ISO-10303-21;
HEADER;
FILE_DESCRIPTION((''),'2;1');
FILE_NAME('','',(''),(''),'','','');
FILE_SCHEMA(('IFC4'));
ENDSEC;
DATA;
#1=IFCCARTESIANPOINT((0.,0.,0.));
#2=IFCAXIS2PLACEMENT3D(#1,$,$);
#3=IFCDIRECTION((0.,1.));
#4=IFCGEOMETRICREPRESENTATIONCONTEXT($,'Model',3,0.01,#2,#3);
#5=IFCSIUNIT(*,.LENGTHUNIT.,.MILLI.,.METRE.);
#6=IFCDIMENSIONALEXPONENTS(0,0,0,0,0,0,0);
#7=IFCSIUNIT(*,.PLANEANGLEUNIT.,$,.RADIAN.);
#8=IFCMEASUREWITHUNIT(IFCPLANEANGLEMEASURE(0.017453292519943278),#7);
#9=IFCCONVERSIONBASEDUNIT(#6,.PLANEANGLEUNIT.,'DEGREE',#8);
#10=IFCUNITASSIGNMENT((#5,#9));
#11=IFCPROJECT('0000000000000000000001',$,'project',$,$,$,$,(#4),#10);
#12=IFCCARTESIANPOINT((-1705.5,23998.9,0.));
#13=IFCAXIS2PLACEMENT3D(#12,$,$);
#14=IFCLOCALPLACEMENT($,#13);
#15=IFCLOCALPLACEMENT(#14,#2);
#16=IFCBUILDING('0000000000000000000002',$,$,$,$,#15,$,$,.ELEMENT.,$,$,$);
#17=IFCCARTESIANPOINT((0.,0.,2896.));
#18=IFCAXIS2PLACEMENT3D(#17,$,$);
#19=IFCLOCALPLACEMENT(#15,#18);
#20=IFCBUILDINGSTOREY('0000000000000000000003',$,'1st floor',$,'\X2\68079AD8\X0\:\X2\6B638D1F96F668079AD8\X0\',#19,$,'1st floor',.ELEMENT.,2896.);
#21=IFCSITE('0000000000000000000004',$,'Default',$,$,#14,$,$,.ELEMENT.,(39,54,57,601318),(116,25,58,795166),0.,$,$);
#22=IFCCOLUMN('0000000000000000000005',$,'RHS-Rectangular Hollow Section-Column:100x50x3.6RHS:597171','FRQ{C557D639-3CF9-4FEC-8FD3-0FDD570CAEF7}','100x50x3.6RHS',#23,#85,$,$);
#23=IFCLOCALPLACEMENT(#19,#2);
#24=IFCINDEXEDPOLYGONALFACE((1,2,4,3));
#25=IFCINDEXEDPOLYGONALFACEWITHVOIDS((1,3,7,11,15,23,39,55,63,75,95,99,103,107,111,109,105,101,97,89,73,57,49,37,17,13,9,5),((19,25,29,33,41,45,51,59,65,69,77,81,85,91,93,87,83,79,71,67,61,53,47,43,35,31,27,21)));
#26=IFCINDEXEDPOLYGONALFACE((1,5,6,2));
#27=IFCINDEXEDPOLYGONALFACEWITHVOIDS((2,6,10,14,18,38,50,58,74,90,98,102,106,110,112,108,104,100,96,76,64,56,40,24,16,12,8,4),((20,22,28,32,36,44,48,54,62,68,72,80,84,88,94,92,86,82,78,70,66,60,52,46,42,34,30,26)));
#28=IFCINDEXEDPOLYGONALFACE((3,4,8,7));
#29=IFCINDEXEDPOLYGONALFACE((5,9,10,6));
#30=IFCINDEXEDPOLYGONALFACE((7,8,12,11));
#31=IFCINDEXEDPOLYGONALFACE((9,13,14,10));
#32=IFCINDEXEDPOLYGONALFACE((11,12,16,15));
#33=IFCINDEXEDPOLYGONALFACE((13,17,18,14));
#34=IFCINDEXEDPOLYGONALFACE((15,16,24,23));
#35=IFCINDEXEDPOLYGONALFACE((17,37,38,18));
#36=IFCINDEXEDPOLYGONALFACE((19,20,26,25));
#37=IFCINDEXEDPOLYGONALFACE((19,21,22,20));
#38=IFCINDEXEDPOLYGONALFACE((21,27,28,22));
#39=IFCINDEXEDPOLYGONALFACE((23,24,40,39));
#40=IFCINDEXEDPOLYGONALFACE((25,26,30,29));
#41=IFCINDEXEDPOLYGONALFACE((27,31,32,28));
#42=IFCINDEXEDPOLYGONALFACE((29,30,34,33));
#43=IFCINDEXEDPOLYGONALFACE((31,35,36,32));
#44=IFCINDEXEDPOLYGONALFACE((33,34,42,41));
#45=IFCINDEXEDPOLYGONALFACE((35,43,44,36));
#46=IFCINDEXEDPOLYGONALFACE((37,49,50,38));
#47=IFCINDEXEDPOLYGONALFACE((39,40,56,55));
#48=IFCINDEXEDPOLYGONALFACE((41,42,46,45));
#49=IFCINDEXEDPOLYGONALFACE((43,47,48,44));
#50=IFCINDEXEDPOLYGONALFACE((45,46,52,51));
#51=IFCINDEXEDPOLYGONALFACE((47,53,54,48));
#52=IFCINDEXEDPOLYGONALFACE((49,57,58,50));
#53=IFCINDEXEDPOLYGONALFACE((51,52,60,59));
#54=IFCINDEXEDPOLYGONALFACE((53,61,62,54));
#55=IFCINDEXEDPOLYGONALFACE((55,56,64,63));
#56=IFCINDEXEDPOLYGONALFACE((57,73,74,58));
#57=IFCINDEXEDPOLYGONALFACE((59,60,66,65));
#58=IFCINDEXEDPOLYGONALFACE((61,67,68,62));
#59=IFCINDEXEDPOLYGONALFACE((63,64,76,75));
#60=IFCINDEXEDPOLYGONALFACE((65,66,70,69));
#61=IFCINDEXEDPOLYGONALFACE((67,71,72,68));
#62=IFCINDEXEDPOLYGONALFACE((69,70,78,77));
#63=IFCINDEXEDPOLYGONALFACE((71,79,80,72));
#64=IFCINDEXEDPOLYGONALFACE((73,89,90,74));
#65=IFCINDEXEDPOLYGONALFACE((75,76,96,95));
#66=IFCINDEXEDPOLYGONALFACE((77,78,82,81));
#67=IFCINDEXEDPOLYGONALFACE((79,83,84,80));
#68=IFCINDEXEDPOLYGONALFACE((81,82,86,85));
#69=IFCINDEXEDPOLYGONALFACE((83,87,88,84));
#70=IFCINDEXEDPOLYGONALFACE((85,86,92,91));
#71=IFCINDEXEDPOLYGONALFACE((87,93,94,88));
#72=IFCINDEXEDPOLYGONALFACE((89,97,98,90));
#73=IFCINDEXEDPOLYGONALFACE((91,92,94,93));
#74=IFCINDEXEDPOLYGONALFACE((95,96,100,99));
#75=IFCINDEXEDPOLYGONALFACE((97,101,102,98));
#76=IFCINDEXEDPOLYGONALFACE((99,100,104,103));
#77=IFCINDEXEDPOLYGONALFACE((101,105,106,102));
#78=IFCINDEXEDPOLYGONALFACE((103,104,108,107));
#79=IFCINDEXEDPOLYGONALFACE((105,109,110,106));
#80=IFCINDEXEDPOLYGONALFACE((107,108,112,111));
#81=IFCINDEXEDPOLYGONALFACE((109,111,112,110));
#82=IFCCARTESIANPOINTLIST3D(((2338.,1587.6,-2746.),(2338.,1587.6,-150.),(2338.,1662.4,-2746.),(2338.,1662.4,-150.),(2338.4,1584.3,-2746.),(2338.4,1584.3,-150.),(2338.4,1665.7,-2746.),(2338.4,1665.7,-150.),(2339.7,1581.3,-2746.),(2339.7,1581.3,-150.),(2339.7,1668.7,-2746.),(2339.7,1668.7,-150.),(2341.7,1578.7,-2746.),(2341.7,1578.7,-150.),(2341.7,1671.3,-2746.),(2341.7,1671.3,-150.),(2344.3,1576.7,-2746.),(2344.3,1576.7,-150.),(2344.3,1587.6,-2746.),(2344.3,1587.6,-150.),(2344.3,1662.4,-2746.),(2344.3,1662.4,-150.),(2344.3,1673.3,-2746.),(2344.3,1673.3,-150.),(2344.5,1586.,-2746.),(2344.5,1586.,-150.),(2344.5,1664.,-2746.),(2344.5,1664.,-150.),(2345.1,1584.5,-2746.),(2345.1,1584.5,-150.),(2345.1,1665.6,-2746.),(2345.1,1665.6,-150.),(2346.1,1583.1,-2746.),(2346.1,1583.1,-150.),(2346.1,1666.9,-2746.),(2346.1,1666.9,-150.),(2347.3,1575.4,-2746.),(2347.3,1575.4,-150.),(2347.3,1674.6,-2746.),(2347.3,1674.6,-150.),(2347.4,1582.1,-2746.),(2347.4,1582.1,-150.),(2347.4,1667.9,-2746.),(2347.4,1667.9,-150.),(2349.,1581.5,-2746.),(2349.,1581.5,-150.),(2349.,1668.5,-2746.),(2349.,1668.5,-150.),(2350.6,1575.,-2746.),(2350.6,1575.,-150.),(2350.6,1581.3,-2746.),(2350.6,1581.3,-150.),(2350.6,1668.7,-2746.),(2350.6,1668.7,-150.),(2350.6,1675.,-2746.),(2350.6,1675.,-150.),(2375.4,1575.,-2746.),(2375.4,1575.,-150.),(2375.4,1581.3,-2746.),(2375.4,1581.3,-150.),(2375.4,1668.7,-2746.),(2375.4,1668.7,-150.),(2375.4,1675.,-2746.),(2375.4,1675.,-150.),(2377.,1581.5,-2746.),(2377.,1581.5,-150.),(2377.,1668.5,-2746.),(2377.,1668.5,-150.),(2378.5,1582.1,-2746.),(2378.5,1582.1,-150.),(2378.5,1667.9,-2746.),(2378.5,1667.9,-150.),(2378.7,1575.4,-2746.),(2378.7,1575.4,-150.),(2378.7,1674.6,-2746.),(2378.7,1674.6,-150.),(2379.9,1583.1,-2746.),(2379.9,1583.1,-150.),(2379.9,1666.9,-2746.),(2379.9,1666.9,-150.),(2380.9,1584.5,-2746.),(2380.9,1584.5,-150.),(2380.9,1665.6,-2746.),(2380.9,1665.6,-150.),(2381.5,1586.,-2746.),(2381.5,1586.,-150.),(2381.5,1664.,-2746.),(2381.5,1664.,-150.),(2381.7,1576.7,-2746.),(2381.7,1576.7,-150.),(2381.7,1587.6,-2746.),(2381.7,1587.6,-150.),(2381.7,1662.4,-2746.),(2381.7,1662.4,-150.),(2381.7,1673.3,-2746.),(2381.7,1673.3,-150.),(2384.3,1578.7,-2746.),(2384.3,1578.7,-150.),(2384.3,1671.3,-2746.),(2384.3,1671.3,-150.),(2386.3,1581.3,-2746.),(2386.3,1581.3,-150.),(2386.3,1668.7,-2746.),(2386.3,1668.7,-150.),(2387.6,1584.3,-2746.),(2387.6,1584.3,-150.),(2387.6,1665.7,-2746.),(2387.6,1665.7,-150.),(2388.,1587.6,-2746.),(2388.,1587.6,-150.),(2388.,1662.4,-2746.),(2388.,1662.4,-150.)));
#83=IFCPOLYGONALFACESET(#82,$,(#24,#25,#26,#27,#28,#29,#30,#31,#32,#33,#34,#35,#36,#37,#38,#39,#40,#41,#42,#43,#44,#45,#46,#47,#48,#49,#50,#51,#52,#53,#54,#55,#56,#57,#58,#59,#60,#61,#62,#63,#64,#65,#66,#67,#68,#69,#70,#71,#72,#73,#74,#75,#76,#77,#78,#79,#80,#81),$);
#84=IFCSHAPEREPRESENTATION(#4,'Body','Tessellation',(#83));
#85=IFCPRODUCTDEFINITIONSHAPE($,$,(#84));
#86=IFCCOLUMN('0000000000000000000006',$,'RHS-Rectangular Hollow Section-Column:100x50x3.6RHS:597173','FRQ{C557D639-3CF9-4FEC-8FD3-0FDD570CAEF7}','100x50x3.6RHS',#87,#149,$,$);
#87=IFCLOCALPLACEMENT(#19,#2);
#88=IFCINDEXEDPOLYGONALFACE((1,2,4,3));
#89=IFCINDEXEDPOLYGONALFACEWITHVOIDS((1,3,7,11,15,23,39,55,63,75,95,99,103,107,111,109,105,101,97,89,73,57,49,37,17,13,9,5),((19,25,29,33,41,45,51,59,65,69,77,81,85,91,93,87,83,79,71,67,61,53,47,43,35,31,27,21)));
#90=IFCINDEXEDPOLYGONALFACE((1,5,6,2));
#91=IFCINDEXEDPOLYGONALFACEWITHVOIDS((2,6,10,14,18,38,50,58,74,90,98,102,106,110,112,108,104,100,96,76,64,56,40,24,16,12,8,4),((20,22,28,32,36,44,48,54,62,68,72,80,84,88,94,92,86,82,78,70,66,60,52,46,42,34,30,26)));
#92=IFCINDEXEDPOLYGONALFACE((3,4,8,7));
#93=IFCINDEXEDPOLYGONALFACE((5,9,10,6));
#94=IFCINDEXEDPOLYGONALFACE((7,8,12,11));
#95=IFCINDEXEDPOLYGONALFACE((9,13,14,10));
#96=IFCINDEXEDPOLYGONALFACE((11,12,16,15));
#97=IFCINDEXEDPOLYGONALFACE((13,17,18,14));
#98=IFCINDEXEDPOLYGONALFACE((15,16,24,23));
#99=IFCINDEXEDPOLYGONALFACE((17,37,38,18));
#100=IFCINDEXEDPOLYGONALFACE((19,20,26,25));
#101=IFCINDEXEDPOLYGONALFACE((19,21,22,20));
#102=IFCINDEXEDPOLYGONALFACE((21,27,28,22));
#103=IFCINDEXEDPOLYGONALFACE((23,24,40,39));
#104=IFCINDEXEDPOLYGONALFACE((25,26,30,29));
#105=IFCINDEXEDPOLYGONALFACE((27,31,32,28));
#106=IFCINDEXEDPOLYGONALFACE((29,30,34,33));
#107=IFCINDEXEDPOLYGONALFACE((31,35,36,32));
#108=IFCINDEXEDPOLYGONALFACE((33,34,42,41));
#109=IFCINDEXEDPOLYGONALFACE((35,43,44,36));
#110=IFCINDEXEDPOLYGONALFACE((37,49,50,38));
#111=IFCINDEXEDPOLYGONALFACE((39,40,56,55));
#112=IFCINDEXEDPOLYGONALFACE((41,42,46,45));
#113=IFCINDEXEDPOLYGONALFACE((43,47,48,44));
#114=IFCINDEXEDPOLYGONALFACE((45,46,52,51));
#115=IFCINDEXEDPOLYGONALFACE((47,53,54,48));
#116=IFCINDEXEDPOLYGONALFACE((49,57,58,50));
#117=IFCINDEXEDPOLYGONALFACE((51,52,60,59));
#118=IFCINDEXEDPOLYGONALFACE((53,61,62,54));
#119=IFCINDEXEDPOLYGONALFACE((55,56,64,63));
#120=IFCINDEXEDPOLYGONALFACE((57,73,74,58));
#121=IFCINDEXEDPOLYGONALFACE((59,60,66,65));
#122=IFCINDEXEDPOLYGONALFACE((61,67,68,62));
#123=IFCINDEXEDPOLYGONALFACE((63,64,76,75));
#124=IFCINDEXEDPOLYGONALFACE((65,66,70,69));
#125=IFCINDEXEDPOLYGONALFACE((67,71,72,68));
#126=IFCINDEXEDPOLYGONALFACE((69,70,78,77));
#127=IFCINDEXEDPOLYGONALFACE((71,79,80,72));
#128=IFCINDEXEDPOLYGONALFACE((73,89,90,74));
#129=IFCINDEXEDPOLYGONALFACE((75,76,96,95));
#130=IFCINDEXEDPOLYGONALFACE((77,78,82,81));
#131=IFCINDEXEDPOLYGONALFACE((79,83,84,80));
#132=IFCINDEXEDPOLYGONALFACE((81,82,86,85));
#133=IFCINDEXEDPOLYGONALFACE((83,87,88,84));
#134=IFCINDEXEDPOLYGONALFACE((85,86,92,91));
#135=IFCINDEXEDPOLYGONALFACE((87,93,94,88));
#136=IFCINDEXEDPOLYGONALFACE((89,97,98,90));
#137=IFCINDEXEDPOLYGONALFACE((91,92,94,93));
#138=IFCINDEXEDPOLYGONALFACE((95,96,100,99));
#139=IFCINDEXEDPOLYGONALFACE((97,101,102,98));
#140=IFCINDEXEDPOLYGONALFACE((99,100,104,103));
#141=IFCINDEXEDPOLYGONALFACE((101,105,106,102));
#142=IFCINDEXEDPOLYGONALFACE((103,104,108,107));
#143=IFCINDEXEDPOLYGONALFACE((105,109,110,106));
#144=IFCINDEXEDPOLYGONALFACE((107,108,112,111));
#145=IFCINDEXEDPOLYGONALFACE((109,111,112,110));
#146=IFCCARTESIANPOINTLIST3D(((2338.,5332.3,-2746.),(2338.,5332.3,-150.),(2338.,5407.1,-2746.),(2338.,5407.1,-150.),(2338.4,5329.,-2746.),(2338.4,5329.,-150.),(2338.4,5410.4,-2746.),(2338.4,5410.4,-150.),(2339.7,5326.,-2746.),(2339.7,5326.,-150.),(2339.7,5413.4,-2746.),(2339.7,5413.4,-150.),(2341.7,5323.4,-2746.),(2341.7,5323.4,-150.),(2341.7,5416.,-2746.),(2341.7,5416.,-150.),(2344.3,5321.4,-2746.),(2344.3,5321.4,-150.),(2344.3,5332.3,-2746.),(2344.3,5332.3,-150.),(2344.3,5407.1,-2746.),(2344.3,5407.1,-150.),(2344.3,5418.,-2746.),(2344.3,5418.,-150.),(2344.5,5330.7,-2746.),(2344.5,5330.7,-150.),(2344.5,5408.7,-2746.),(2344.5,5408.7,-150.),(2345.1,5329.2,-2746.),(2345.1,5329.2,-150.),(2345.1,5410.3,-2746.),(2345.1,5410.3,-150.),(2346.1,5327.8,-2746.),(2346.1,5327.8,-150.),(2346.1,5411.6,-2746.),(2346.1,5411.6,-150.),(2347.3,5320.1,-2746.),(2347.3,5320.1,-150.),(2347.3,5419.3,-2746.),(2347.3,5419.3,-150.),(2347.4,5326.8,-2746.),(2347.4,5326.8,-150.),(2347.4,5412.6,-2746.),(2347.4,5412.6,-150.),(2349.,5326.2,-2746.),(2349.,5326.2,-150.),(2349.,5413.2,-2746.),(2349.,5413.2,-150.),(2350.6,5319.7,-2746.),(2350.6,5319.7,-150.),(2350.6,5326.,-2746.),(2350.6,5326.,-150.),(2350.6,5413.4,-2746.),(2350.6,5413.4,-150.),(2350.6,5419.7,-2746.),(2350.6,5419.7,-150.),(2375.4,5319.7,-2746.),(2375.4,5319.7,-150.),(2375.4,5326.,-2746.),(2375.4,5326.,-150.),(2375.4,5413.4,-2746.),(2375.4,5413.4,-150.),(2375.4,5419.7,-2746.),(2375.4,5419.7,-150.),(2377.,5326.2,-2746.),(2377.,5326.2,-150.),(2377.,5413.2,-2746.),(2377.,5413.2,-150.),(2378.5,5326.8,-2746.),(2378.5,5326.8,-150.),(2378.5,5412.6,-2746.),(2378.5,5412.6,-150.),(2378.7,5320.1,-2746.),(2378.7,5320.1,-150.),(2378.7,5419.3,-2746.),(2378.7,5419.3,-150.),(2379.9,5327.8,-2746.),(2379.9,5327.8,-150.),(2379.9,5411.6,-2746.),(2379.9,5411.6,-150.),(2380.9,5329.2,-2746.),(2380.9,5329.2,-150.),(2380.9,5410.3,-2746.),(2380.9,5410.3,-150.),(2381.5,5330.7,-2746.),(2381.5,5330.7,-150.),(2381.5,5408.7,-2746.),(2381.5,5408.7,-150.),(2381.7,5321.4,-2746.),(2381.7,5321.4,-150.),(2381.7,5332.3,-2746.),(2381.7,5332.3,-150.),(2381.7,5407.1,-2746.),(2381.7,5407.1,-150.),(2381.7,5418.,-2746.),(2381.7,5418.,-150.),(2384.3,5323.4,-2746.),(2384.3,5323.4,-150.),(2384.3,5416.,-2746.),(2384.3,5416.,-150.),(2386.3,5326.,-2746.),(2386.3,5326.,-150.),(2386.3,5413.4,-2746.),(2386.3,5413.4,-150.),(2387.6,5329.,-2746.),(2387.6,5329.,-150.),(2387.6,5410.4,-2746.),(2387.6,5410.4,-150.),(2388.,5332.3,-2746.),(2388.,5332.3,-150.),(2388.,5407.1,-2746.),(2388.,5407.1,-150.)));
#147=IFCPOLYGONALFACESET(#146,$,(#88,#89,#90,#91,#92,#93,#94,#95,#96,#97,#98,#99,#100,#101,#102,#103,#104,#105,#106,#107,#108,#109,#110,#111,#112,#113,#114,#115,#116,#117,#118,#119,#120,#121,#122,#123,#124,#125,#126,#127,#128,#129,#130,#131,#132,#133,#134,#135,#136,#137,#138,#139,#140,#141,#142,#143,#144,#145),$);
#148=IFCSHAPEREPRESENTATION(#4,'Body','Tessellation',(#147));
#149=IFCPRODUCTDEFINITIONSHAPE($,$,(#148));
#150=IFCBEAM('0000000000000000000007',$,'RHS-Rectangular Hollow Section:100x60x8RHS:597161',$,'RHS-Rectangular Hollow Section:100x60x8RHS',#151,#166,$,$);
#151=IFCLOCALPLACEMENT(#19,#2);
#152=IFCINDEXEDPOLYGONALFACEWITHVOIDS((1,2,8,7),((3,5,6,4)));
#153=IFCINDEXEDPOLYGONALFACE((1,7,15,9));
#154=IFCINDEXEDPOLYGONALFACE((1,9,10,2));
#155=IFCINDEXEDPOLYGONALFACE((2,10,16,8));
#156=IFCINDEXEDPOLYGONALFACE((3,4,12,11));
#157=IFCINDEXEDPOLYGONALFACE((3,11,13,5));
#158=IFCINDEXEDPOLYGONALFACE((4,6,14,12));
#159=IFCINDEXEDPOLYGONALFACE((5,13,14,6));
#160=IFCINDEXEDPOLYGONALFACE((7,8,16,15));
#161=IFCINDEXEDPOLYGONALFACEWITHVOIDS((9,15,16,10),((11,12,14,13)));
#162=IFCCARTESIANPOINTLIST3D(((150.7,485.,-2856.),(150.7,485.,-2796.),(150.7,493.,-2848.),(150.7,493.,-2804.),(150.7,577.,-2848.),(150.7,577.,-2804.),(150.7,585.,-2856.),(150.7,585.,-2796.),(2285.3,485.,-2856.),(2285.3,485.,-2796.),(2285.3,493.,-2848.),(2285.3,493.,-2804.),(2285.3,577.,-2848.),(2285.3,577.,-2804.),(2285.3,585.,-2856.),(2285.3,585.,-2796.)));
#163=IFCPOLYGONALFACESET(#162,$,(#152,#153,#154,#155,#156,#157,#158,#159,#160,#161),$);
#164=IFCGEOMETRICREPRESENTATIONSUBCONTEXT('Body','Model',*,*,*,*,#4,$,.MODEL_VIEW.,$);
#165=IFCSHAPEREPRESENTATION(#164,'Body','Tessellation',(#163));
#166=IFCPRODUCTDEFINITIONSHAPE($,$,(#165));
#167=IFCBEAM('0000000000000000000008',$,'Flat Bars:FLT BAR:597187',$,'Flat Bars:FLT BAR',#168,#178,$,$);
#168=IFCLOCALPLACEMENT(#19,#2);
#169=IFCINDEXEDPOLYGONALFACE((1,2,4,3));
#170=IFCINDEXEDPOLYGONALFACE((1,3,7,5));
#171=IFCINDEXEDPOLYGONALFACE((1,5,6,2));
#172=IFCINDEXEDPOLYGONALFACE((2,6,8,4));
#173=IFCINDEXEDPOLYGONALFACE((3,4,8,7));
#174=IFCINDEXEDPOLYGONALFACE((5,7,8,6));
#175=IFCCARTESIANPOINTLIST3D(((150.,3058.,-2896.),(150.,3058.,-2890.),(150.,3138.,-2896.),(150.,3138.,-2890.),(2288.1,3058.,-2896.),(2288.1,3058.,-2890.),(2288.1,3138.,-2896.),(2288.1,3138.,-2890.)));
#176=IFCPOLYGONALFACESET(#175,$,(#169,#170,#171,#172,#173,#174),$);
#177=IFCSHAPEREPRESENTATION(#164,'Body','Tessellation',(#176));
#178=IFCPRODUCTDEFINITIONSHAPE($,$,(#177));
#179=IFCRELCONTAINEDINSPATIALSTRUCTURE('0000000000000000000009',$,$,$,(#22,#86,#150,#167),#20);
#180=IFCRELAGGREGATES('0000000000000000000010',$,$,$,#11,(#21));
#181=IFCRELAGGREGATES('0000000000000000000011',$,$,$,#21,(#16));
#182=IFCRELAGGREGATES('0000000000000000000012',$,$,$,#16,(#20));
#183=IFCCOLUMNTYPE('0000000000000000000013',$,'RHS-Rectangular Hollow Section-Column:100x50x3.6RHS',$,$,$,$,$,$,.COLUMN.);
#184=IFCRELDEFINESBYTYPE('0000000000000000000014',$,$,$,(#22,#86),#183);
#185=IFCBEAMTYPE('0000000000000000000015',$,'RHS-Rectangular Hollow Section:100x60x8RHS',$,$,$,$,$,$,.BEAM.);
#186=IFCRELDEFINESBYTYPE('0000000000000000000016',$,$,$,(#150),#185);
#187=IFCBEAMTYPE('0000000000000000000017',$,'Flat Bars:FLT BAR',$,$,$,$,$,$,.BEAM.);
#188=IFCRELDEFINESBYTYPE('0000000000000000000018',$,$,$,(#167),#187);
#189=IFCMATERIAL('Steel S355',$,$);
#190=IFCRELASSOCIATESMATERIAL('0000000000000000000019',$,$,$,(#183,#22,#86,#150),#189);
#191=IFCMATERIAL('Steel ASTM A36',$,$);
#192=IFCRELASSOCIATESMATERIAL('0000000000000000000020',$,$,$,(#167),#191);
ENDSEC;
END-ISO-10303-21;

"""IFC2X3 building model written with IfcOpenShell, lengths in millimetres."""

from ifc_helpers import new_model, entity, si_unit, converted_unit, direction, frame, frame_2d, origin, origin_2d, origin_2d_with_axis, place, context, subcontext, project, spatial, rectangle, hollow_rectangle, extrude, boolean, clip, halfspace, material, type_object, element, save


model = new_model("IFC2X3")

# Units and contexts
model_context = context("Model", 3, precision=0.01, world=origin(), true_north=direction((0.0, 1.0)))
body_context = subcontext(model_context, "Body", "Model", "MODEL_VIEW")
ifc_project = project(units=[si_unit("LENGTHUNIT", "METRE", prefix="MILLI"), converted_unit("PLANEANGLEUNIT", "DEGREE", entity("IfcPlaneAngleMeasure", 0.017453292519943278), si_unit("PLANEANGLEUNIT", "RADIAN"), dimensions=[0, 0, 0, 0, 0, 0, 0])], contexts=[model_context])

# Site, building, storey
site_placement = place(None, frame((-1705.5, 23998.9, 0.0)))
site = spatial("IfcSite", under=ifc_project, at=site_placement, Name="Default", CompositionType="ELEMENT", RefLatitude=(39, 54, 57, 601318), RefLongitude=(116, 25, 58, 795166), RefElevation=0.0)
building_placement = place(site_placement, origin())
building = spatial("IfcBuilding", under=site, at=building_placement, CompositionType="ELEMENT")
storey_placement = place(building_placement, frame((0.0, 0.0, 2896.0)))
storey = spatial("IfcBuildingStorey", under=building, at=storey_placement, Name="1st floor", ObjectType="标高:正负零标高", LongName="1st floor", CompositionType="ELEMENT", Elevation=2896.0)

# Shared definitions
ifc_material_1 = material(Name="Steel S355")

# Columns
column_type_1 = type_object("IfcColumnType", Name="RHS-Rectangular Hollow Section-Column:100x50x3.6RHS", PredefinedType="COLUMN", material=ifc_material_1)
column_1_placement = place(storey_placement, frame((2363.0, 1625.0, -150.0), z_axis=(0.0, 0.0, 1.0), x_axis=(-1.0, 0.0, 0.0)))
element("IfcColumn", 1, at=column_1_placement, inside=storey, type_object=column_type_1, material=ifc_material_1, Name="RHS-Rectangular Hollow Section-Column:100x50x3.6RHS:597171", Description="FRQ{C557D639-3CF9-4FEC-8FD3-0FDD570CAEF7}", ObjectType="100x50x3.6RHS", context=model_context, shape_type="Clipping", body=[
    clip(extrude(hollow_rectangle(XDim=50.0, YDim=100.0, WallThickness=6.3, InnerFilletRadius=6.3, OuterFilletRadius=12.6, at=origin_2d()), origin(), (0.0, 0.0, -1.0), 2651.9), halfspace(frame((2363.0, 1625.0, -2596.0), z_axis=(0.0, 0.0, 1.0), x_axis=(-1.0, 0.0, 0.0)), True)),
])
column_2_placement = place(storey_placement, frame((2363.0, 5369.7, -150.0), z_axis=(0.0, 0.0, 1.0), x_axis=(-1.0, 0.0, 0.0)))
element("IfcColumn", 2, at=column_2_placement, inside=storey, type_object=column_type_1, material=ifc_material_1, Name="RHS-Rectangular Hollow Section-Column:100x50x3.6RHS:597173", Description="FRQ{C557D639-3CF9-4FEC-8FD3-0FDD570CAEF7}", ObjectType="100x50x3.6RHS", context=model_context, shape_type="Clipping", body=[
    clip(extrude(hollow_rectangle(XDim=50.0, YDim=100.0, WallThickness=6.3, InnerFilletRadius=6.3, OuterFilletRadius=12.6, at=origin_2d()), origin(), (0.0, 0.0, -1.0), 2651.9), halfspace(frame((2363.0, 5369.7, -2596.0), z_axis=(0.0, 0.0, 1.0), x_axis=(-1.0, 0.0, 0.0)), True)),
])

# Beams
beam_type_1 = type_object("IfcBeamType", Name="RHS-Rectangular Hollow Section:100x60x8RHS", PredefinedType="BEAM")
beam_1_placement = place(storey_placement, frame((150.7, 585.0, -2826.0)))
element("IfcBeam", 3, at=beam_1_placement, inside=storey, type_object=beam_type_1, material=ifc_material_1, Name="RHS-Rectangular Hollow Section:100x60x8RHS:597161", ObjectType="RHS-Rectangular Hollow Section:100x60x8RHS", context=body_context, shape_type="SweptSolid", body=[
    boolean("DIFFERENCE", extrude(rectangle(XDim=60.0, YDim=100.0, at=frame_2d((0.0, 0.0), x_axis=(1.0, 0.0))), frame((0.0, -50.0, 0.0), z_axis=(1.0, 0.0, 0.0), x_axis=(0.0, 0.0, -1.0)), (0.0, 0.0, 1.0), 2134.6), extrude(rectangle(XDim=44.0, YDim=84.0, at=frame_2d((0.0, 0.0), x_axis=(0.0, 1.0))), frame((2134.6, -50.0, 0.0), z_axis=(-1.0, 0.0, 0.0), x_axis=(0.0, 1.0, 0.0)), (0.0, 0.0, 1.0), 2134.6)),
])
ifc_material_2 = material(Name="Steel ASTM A36")
beam_type_2 = type_object("IfcBeamType", Name="Flat Bars:FLT BAR", PredefinedType="BEAM")
beam_2_placement = place(storey_placement, frame((150.0, 3098.0, -2890.0)))
element("IfcBeam", 4, at=beam_2_placement, inside=storey, type_object=beam_type_2, material=ifc_material_2, Name="Flat Bars:FLT BAR:597187", ObjectType="Flat Bars:FLT BAR", context=body_context, shape_type="SweptSolid", body=[
    extrude(rectangle(XDim=6.0, YDim=80.0, at=origin_2d_with_axis()), frame((0.0, 0.0, -3.0), z_axis=(1.0, 0.0, 0.0), x_axis=(0.0, 0.0, -1.0)), (0.0, 0.0, 1.0), 2138.1),
])

save(model, "model.ifc")
